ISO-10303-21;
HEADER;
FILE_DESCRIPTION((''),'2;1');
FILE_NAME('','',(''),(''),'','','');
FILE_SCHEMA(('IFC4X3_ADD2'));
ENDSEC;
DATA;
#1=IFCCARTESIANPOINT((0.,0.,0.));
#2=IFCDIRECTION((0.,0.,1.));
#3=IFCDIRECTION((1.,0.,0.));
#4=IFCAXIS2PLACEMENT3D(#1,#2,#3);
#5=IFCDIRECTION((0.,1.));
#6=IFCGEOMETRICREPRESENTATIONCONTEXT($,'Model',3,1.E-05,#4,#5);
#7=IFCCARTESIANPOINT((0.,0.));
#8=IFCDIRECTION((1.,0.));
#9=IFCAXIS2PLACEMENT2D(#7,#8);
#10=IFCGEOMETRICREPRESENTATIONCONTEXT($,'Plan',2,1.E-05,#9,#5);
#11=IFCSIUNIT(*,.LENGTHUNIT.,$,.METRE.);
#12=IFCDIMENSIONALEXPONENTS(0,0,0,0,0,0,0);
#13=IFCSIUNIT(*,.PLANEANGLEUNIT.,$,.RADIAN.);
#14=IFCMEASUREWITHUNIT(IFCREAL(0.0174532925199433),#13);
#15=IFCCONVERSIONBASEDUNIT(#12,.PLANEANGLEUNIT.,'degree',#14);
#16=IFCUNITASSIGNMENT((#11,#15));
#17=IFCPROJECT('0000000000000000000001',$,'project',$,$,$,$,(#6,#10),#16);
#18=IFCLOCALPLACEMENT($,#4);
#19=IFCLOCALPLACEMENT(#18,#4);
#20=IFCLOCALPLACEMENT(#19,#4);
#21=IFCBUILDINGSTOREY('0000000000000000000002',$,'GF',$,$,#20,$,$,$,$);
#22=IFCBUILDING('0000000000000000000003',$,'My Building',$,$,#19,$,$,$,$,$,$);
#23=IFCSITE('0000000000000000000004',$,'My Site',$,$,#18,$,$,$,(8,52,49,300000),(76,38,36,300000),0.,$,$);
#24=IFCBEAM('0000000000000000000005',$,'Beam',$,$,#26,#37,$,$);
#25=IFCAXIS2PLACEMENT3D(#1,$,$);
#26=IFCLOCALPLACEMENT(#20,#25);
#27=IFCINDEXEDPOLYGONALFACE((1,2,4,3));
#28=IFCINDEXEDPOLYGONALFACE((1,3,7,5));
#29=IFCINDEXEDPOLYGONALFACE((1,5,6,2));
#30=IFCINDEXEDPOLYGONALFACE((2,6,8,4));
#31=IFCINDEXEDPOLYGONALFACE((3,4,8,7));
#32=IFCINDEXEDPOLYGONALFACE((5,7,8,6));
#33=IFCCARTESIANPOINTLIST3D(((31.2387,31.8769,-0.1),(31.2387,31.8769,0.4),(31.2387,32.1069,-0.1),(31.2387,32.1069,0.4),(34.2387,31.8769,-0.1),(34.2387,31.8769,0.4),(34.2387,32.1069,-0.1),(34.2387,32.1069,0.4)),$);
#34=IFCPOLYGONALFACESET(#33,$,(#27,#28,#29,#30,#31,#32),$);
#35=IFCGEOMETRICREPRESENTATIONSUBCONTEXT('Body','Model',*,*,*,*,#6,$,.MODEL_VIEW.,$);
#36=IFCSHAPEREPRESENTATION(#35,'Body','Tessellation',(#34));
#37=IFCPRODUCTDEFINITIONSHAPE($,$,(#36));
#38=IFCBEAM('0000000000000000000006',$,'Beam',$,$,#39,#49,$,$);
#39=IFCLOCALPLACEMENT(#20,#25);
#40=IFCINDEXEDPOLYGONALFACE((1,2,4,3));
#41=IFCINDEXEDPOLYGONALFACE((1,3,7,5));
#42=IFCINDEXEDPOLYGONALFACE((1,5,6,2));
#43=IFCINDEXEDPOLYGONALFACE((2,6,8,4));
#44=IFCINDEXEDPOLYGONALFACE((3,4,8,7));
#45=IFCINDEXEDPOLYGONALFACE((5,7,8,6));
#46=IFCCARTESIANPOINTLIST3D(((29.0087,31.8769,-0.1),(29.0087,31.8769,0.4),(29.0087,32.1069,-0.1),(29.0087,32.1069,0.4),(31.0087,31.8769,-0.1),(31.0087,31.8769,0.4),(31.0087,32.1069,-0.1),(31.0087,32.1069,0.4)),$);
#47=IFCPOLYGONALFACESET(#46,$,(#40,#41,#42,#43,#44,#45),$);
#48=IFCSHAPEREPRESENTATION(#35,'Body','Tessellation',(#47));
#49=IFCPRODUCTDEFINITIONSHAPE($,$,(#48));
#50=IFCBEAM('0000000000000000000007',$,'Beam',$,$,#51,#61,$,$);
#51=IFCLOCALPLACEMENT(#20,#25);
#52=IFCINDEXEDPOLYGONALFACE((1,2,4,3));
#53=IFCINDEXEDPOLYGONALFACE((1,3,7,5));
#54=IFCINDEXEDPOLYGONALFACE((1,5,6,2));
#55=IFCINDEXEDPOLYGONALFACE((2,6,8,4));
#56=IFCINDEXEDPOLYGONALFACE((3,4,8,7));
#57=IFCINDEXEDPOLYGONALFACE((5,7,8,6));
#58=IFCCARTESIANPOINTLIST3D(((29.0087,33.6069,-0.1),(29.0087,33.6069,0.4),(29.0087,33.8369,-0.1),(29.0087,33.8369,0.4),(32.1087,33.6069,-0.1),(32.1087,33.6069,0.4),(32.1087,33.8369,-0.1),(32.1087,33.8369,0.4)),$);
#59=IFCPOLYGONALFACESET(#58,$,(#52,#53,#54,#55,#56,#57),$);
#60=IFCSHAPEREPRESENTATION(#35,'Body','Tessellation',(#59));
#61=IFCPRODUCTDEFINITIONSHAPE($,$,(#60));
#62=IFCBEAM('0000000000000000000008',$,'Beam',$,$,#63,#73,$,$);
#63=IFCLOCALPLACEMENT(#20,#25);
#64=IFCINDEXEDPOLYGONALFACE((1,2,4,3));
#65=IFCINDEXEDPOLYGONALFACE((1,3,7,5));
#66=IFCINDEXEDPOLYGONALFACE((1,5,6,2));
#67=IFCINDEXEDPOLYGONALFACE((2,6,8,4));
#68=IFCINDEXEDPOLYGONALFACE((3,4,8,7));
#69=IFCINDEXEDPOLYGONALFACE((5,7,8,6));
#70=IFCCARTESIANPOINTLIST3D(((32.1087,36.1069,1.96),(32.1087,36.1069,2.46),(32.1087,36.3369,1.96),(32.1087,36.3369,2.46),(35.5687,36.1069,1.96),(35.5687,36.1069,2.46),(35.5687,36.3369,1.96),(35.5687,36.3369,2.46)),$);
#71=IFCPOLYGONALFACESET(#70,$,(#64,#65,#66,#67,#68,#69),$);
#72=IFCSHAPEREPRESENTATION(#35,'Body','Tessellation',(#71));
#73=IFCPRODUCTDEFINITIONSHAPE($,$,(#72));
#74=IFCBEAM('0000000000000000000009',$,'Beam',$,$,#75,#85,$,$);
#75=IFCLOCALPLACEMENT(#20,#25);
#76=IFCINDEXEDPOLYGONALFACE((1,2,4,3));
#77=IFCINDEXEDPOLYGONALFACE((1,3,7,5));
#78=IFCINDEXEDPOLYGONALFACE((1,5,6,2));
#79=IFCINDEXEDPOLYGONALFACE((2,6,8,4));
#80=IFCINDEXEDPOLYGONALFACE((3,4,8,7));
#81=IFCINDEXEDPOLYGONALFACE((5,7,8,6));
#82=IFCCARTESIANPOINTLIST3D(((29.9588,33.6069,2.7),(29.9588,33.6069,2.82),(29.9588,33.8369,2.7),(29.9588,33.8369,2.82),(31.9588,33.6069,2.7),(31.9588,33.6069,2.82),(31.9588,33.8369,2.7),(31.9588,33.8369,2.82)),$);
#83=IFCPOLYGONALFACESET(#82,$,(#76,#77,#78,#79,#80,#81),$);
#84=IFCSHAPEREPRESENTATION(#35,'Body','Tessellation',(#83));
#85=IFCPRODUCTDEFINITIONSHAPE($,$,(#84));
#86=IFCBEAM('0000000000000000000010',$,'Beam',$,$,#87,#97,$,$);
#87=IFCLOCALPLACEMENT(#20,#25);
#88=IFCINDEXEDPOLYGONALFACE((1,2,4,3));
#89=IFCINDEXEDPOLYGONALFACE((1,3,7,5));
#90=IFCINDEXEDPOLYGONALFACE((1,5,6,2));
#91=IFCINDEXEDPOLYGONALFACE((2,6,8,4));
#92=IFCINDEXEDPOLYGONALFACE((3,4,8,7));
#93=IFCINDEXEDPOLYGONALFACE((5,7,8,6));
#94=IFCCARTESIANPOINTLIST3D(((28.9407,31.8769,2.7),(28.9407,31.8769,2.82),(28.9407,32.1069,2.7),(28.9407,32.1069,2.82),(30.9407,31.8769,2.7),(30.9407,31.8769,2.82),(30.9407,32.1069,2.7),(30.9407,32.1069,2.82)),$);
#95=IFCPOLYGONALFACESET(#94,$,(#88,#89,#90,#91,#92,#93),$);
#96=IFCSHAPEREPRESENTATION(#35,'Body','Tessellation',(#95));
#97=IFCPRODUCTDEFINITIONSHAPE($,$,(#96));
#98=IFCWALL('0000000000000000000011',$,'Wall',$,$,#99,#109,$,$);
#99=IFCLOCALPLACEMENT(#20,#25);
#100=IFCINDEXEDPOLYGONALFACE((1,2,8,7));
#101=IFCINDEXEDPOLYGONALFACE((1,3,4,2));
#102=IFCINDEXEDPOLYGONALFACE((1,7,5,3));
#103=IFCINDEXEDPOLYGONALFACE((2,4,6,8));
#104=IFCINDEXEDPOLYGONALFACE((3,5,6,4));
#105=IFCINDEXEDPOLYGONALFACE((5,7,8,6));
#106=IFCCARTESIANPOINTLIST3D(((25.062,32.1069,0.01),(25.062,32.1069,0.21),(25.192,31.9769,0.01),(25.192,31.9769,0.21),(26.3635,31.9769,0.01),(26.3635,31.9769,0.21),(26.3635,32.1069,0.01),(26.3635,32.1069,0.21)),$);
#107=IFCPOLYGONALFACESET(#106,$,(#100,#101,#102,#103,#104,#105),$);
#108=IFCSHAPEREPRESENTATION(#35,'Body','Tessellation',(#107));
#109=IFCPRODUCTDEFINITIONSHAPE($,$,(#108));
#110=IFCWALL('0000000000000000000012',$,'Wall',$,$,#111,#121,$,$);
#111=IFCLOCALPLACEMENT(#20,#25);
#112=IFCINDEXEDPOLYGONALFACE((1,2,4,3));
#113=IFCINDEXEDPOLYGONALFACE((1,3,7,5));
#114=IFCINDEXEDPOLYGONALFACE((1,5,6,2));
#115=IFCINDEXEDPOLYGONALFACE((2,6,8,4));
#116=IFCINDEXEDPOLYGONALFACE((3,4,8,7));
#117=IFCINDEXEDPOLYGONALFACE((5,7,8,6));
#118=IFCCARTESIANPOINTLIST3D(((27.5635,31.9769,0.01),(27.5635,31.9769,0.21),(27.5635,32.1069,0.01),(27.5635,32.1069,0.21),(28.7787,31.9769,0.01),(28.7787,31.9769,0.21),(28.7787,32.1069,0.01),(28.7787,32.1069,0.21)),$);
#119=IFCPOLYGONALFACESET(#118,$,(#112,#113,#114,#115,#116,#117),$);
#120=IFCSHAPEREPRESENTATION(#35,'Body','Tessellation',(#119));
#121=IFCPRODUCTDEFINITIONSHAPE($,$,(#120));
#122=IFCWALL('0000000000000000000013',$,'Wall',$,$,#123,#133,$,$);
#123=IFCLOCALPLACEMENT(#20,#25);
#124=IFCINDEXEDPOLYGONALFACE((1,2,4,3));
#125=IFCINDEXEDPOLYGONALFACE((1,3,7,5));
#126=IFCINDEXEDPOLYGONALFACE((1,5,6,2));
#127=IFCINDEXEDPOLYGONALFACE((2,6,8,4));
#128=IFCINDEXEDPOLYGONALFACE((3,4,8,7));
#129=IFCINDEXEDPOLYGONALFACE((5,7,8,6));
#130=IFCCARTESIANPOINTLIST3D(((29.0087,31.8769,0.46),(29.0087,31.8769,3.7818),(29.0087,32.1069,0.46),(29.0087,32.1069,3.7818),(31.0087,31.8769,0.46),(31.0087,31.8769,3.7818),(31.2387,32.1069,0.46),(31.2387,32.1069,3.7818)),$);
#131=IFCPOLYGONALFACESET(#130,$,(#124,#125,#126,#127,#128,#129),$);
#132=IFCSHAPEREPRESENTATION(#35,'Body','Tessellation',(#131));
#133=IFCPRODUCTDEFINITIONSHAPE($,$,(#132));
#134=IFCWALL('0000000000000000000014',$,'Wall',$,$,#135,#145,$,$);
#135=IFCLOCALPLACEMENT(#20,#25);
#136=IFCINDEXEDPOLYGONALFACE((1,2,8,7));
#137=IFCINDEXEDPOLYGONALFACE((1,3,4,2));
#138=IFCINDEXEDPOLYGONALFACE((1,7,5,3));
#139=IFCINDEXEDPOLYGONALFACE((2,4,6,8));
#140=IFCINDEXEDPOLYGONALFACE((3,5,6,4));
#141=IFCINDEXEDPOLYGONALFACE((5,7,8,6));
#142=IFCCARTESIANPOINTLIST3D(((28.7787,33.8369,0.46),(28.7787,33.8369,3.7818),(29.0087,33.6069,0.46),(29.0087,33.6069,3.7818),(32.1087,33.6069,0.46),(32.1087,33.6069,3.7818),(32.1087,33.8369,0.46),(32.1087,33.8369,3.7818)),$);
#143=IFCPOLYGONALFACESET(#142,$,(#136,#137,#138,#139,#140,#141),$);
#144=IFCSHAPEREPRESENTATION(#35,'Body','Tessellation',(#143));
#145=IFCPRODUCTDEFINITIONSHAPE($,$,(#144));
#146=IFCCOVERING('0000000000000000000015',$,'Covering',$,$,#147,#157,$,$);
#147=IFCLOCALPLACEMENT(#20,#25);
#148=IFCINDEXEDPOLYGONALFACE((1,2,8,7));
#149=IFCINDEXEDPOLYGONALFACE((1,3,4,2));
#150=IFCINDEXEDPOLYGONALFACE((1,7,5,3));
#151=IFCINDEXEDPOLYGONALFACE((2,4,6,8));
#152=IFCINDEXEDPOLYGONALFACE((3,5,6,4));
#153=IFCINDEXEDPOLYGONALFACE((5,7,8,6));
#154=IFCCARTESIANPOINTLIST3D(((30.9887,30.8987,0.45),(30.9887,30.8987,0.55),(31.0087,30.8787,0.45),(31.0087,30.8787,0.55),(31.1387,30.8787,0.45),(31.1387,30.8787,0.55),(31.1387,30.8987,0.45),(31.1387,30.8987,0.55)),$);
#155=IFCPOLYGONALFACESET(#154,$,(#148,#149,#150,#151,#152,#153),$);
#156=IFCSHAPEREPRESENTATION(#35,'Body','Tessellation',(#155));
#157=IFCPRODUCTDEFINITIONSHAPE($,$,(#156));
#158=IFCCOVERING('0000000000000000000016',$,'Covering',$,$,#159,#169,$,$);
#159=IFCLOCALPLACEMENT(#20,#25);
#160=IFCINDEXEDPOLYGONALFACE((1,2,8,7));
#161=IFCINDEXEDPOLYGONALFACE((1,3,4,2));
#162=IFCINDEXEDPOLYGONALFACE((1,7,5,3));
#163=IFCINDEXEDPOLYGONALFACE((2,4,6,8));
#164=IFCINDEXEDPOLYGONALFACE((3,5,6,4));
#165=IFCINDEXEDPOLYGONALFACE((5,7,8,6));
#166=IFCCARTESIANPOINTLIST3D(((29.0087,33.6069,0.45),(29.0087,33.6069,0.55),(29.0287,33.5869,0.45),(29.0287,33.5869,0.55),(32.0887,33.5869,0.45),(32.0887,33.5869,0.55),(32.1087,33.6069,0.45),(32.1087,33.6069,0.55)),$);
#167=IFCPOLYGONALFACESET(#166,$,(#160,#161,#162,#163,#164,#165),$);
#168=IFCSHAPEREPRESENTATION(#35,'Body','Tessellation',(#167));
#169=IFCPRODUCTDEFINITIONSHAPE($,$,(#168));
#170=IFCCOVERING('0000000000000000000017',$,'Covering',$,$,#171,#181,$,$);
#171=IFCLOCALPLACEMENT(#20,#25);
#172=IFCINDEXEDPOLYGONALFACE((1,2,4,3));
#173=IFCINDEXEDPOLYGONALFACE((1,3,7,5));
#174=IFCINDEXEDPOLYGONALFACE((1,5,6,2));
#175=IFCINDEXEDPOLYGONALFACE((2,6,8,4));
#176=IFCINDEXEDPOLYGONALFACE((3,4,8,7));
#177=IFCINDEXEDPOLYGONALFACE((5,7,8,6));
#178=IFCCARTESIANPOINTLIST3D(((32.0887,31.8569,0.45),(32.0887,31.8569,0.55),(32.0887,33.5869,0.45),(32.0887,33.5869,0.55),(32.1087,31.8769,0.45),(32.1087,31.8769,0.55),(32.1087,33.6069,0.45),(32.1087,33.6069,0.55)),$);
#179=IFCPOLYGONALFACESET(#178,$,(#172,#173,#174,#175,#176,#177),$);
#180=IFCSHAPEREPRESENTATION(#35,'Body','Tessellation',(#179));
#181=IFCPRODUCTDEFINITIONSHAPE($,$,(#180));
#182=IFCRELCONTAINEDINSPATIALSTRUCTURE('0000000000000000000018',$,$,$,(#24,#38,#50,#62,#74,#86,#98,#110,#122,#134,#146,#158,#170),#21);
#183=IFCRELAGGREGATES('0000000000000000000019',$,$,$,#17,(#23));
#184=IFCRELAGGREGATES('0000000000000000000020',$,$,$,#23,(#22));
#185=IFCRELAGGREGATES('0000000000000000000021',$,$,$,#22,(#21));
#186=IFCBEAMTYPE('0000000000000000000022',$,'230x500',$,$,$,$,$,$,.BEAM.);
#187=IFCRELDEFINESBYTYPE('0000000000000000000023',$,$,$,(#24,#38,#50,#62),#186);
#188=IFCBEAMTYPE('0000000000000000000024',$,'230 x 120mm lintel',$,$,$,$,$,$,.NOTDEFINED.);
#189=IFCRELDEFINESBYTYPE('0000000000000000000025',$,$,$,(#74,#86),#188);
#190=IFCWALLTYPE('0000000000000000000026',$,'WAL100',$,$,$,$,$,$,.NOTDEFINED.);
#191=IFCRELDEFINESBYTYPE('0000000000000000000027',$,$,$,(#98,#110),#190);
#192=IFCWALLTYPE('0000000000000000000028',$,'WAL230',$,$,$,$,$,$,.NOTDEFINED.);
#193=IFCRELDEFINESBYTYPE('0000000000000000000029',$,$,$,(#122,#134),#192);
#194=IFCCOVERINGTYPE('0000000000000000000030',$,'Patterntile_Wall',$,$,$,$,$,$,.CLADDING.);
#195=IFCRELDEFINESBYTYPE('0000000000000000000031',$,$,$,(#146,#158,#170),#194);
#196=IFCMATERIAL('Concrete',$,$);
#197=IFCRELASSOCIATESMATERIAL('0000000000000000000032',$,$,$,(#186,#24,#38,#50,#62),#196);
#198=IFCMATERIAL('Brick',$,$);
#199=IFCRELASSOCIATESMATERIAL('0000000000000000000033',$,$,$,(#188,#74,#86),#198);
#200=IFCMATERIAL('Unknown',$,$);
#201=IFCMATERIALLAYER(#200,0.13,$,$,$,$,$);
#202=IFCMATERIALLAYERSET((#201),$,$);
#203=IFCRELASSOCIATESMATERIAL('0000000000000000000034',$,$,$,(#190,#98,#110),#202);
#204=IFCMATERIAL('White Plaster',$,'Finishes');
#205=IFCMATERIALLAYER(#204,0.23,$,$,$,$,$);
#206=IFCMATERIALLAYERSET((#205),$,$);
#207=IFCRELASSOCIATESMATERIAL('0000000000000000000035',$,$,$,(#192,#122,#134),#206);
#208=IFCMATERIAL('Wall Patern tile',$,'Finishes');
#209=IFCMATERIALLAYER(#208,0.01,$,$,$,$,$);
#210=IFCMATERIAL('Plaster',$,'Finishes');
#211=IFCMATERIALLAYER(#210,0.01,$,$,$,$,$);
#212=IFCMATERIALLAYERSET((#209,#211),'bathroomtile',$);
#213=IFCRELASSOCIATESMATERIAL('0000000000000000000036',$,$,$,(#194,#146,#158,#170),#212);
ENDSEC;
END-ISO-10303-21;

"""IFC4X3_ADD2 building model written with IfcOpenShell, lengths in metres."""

from ifc_helpers import new_model, entity, si_unit, converted_unit, direction, frame, origin_with_axes, origin_2d_with_axis, place, context, subcontext, project, spatial, line, indexed_curve, rectangle, outline, extrude, material, layer, layer_set, layer_usage, material_profile, profile_set, profile_usage, type_object, element, save


model = new_model("IFC4X3_ADD2")

# Units and contexts
model_context = context("Model", 3, precision=1e-05, world=origin_with_axes(), true_north=direction((0.0, 1.0)))
plan_context = context("Plan", 2, precision=1e-05, world=origin_2d_with_axis(), true_north=direction((0.0, 1.0)))
body_context = subcontext(model_context, "Body", "Model", "MODEL_VIEW")
ifc_project = project(units=[si_unit("LENGTHUNIT", "METRE"), converted_unit("PLANEANGLEUNIT", "degree", entity("IfcReal", 0.0174532925199433), si_unit("PLANEANGLEUNIT", "RADIAN"), dimensions=[0, 0, 0, 0, 0, 0, 0])], contexts=[model_context, plan_context])

# Site, building, storey
site_placement = place(None, origin_with_axes())
site = spatial("IfcSite", under=ifc_project, at=site_placement, Name="My Site", RefLatitude=(8, 52, 49, 300000), RefLongitude=(76, 38, 36, 300000), RefElevation=0.0)
building_placement = place(site_placement, origin_with_axes())
building = spatial("IfcBuilding", under=site, at=building_placement, Name="My Building")
storey_placement = place(building_placement, origin_with_axes())
storey = spatial("IfcBuildingStorey", under=building, at=storey_placement, Name="GF")

# Beams
ifc_material_1 = material(Name="Concrete")
ifc_material_profile_1 = material_profile(ifc_material_1, rectangle(XDim=0.23, YDim=0.5))
ifc_profile_set_1 = profile_set([ifc_material_profile_1])
ifc_profile_usage_1 = profile_usage(ifc_profile_set_1, cardinal=5)
beam_type_1 = type_object("IfcBeamType", Name="230x500", PredefinedType="BEAM", material=ifc_profile_set_1)
beam_1_placement = place(storey_placement, frame((31.2387, 31.9919, 0.15), z_axis=(1.0, 0.0, 0.0), x_axis=(0.0, 1.0, 0.0)))
element("IfcBeam", 1, at=beam_1_placement, inside=storey, type_object=beam_type_1, material=ifc_profile_usage_1, Name="Beam", context=body_context, shape_type="SweptSolid", body=[
    extrude(rectangle(XDim=0.23, YDim=0.5), origin_with_axes(), (0.0, 0.0, 1.0), 3.0),
])
ifc_profile_usage_2 = profile_usage(ifc_profile_set_1, cardinal=5)
beam_2_placement = place(storey_placement, frame((29.0087, 31.9919, 0.15), z_axis=(1.0, 0.0, 0.0), x_axis=(0.0, 1.0, 0.0)))
element("IfcBeam", 2, at=beam_2_placement, inside=storey, type_object=beam_type_1, material=ifc_profile_usage_2, Name="Beam", context=body_context, shape_type="SweptSolid", body=[
    extrude(rectangle(XDim=0.23, YDim=0.5), origin_with_axes(), (0.0, 0.0, 1.0), 2.0),
])
ifc_profile_usage_3 = profile_usage(ifc_profile_set_1, cardinal=5)
beam_3_placement = place(storey_placement, frame((29.0087, 33.7219, 0.15), z_axis=(1.0, 0.0, 0.0), x_axis=(0.0, 1.0, 0.0)))
element("IfcBeam", 3, at=beam_3_placement, inside=storey, type_object=beam_type_1, material=ifc_profile_usage_3, Name="Beam", context=body_context, shape_type="SweptSolid", body=[
    extrude(rectangle(XDim=0.23, YDim=0.5), origin_with_axes(), (0.0, 0.0, 1.0), 3.1),
])
ifc_profile_usage_4 = profile_usage(ifc_profile_set_1, cardinal=5)
beam_4_placement = place(storey_placement, frame((32.1087, 36.2219, 2.21), z_axis=(1.0, 0.0, 0.0), x_axis=(0.0, 1.0, 0.0)))
element("IfcBeam", 4, at=beam_4_placement, inside=storey, type_object=beam_type_1, material=ifc_profile_usage_4, Name="Beam", context=body_context, shape_type="SweptSolid", body=[
    extrude(rectangle(XDim=0.23, YDim=0.5), origin_with_axes(), (0.0, 0.0, 1.0), 3.46),
])
ifc_material_2 = material(Name="Brick")
ifc_material_profile_2 = material_profile(ifc_material_2, rectangle(XDim=0.23, YDim=0.12))
ifc_profile_set_2 = profile_set([ifc_material_profile_2], Name="blank")
ifc_profile_usage_5 = profile_usage(ifc_profile_set_2, cardinal=5)
beam_type_2 = type_object("IfcBeamType", Name="230 x 120mm lintel", PredefinedType="NOTDEFINED", material=ifc_profile_set_2)
beam_5_placement = place(storey_placement, frame((31.9588, 33.7219, 2.76), z_axis=(-1.0, 0.0, 0.0), x_axis=(0.0, -1.0, 0.0)))
element("IfcBeam", 5, at=beam_5_placement, inside=storey, type_object=beam_type_2, material=ifc_profile_usage_5, Name="Beam", context=body_context, shape_type="SweptSolid", body=[
    extrude(rectangle(XDim=0.23, YDim=0.12), origin_with_axes(), (0.0, 0.0, 1.0), 2.0),
])
ifc_profile_usage_6 = profile_usage(ifc_profile_set_2, cardinal=5)
beam_6_placement = place(storey_placement, frame((30.9407, 31.9919, 2.76), z_axis=(-1.0, 0.0, 0.0), x_axis=(0.0, -1.0, 0.0)))
element("IfcBeam", 6, at=beam_6_placement, inside=storey, type_object=beam_type_2, material=ifc_profile_usage_6, Name="Beam", context=body_context, shape_type="SweptSolid", body=[
    extrude(rectangle(XDim=0.23, YDim=0.12), origin_with_axes(), (0.0, 0.0, 1.0), 2.0),
])

# Walls
ifc_material_3 = material(Name="Unknown")
ifc_layer_1 = layer(ifc_material_3, 0.13)
ifc_layer_set_1 = layer_set([ifc_layer_1])
ifc_layer_usage_1 = layer_usage(ifc_layer_set_1, "AXIS2", "NEGATIVE", 0.0)
wall_type_1 = type_object("IfcWallType", Name="WAL100", PredefinedType="NOTDEFINED", material=ifc_layer_set_1)
wall_1_placement = place(storey_placement, frame((25.192, 32.1069, 0.01), z_axis=(0.0, 0.0, 1.0), x_axis=(1.0, 0.0, 0.0)))
element("IfcWall", 7, at=wall_1_placement, inside=storey, type_object=wall_type_1, material=ifc_layer_usage_1, Name="Wall", context=body_context, shape_type="SweptSolid", body=[
    extrude(outline(indexed_curve([(0.0, -0.13), (-0.13, 0.0), (1.1715, 0.0), (1.1715, -0.13)], segments=[line(1, 2, 3, 4, 1)])), origin_with_axes(), (0.0, 0.0, 1.0), 0.2),
])
ifc_layer_usage_2 = layer_usage(ifc_layer_set_1, "AXIS2", "NEGATIVE", 0.0)
wall_2_placement = place(storey_placement, frame((27.5635, 32.1069, 0.01), z_axis=(0.0, 0.0, 1.0), x_axis=(1.0, 0.0, 0.0)))
element("IfcWall", 8, at=wall_2_placement, inside=storey, type_object=wall_type_1, material=ifc_layer_usage_2, Name="Wall", context=body_context, shape_type="SweptSolid", body=[
    extrude(outline(indexed_curve([(0.0, -0.13), (0.0, 0.0), (1.2152, 0.0), (1.2152, -0.13)], segments=[line(1, 2, 3, 4, 1)])), origin_with_axes(), (0.0, 0.0, 1.0), 0.2),
])

# Shared definitions
ifc_material_4 = material(Name="White Plaster", Category="Finishes")
ifc_layer_2 = layer(ifc_material_4, 0.23)
ifc_layer_set_2 = layer_set([ifc_layer_2])
wall_type_2 = type_object("IfcWallType", Name="WAL230", PredefinedType="NOTDEFINED", material=ifc_layer_set_2)

# Walls
ifc_layer_usage_3 = layer_usage(ifc_layer_set_2, "AXIS2", "POSITIVE", 0.0)
wall_3_placement = place(storey_placement, frame((29.0087, 31.8769, 0.46), z_axis=(0.0, 0.0, 1.0), x_axis=(1.0, -0.000001, 0.0)))
element("IfcWall", 9, at=wall_3_placement, inside=storey, type_object=wall_type_2, material=ifc_layer_usage_3, Name="Wall", context=body_context, shape_type="SweptSolid", body=[
    extrude(outline(indexed_curve([(0.0, 0.0), (0.0, 0.23), (2.23, 0.23), (2.0, 0.0)], segments=[line(1, 2, 3, 4, 1)])), origin_with_axes(), (0.0, 0.0, 1.0), 3.3218),
])
ifc_layer_usage_4 = layer_usage(ifc_layer_set_2, "AXIS2", "POSITIVE", 0.0)
wall_4_placement = place(storey_placement, frame((29.0087, 33.6069, 0.46), z_axis=(0.0, 0.0, 1.0), x_axis=(1.0, -0.000001, 0.0)))
element("IfcWall", 10, at=wall_4_placement, inside=storey, type_object=wall_type_2, material=ifc_layer_usage_4, Name="Wall", context=body_context, shape_type="SweptSolid", body=[
    extrude(outline(indexed_curve([(0.0, 0.0), (-0.23, 0.23), (3.1, 0.23), (3.1, 0.0)], segments=[line(1, 2, 3, 4, 1)])), origin_with_axes(), (0.0, 0.0, 1.0), 3.3218),
])

# Coverings
ifc_material_5 = material(Name="Wall Patern tile", Category="Finishes")
ifc_layer_3 = layer(ifc_material_5, 0.01)
ifc_material_6 = material(Name="Plaster", Category="Finishes")
ifc_layer_4 = layer(ifc_material_6, 0.01)
ifc_layer_set_3 = layer_set([ifc_layer_3, ifc_layer_4], Name="bathroomtile")
ifc_layer_usage_5 = layer_usage(ifc_layer_set_3, "AXIS2", "POSITIVE", 0.0)
covering_type = type_object("IfcCoveringType", Name="Patterntile_Wall", PredefinedType="CLADDING", material=ifc_layer_set_3)
covering_1_placement = place(storey_placement, frame((31.1387, 30.8987, 0.45), z_axis=(0.0, 0.0, 1.0), x_axis=(-1.0, 0.000001, 0.0)))
element("IfcCovering", 11, at=covering_1_placement, inside=storey, type_object=covering_type, material=ifc_layer_usage_5, Name="Covering", context=body_context, shape_type="SweptSolid", body=[
    extrude(outline(indexed_curve([(0.0, 0.0), (0.0, 0.02), (0.13, 0.02), (0.15, 0.0)], segments=[line(1, 2, 3, 4, 1)])), origin_with_axes(), (0.0, 0.0, 1.0), 0.1),
])
ifc_layer_usage_6 = layer_usage(ifc_layer_set_3, "AXIS2", "NEGATIVE", 0.0)
covering_2_placement = place(storey_placement, frame((32.0887, 33.5869, 0.45), z_axis=(0.0, 0.0, 1.0), x_axis=(-1.0, 0.000001, 0.0)))
element("IfcCovering", 12, at=covering_2_placement, inside=storey, type_object=covering_type, material=ifc_layer_usage_6, Name="Covering", context=body_context, shape_type="SweptSolid", body=[
    extrude(outline(indexed_curve([(-0.02, -0.02), (0.0, 0.0), (3.06, 0.0), (3.08, -0.02)], segments=[line(1, 2, 3, 4, 1)])), origin_with_axes(), (0.0, 0.0, 1.0), 0.1),
])
ifc_layer_usage_7 = layer_usage(ifc_layer_set_3, "AXIS2", "NEGATIVE", 0.0)
covering_3_placement = place(storey_placement, frame((32.0887, 31.8569, 0.45), z_axis=(0.0, 0.0, 1.0), x_axis=(0.0, 1.0, 0.0)))
element("IfcCovering", 13, at=covering_3_placement, inside=storey, type_object=covering_type, material=ifc_layer_usage_7, Name="Covering", context=body_context, shape_type="SweptSolid", body=[
    extrude(outline(indexed_curve([(0.02, -0.02), (0.0, 0.0), (1.73, 0.0), (1.75, -0.02)], segments=[line(1, 2, 3, 4, 1)])), origin_with_axes(), (0.0, 0.0, 1.0), 0.1),
])

save(model, "model.ifc")
